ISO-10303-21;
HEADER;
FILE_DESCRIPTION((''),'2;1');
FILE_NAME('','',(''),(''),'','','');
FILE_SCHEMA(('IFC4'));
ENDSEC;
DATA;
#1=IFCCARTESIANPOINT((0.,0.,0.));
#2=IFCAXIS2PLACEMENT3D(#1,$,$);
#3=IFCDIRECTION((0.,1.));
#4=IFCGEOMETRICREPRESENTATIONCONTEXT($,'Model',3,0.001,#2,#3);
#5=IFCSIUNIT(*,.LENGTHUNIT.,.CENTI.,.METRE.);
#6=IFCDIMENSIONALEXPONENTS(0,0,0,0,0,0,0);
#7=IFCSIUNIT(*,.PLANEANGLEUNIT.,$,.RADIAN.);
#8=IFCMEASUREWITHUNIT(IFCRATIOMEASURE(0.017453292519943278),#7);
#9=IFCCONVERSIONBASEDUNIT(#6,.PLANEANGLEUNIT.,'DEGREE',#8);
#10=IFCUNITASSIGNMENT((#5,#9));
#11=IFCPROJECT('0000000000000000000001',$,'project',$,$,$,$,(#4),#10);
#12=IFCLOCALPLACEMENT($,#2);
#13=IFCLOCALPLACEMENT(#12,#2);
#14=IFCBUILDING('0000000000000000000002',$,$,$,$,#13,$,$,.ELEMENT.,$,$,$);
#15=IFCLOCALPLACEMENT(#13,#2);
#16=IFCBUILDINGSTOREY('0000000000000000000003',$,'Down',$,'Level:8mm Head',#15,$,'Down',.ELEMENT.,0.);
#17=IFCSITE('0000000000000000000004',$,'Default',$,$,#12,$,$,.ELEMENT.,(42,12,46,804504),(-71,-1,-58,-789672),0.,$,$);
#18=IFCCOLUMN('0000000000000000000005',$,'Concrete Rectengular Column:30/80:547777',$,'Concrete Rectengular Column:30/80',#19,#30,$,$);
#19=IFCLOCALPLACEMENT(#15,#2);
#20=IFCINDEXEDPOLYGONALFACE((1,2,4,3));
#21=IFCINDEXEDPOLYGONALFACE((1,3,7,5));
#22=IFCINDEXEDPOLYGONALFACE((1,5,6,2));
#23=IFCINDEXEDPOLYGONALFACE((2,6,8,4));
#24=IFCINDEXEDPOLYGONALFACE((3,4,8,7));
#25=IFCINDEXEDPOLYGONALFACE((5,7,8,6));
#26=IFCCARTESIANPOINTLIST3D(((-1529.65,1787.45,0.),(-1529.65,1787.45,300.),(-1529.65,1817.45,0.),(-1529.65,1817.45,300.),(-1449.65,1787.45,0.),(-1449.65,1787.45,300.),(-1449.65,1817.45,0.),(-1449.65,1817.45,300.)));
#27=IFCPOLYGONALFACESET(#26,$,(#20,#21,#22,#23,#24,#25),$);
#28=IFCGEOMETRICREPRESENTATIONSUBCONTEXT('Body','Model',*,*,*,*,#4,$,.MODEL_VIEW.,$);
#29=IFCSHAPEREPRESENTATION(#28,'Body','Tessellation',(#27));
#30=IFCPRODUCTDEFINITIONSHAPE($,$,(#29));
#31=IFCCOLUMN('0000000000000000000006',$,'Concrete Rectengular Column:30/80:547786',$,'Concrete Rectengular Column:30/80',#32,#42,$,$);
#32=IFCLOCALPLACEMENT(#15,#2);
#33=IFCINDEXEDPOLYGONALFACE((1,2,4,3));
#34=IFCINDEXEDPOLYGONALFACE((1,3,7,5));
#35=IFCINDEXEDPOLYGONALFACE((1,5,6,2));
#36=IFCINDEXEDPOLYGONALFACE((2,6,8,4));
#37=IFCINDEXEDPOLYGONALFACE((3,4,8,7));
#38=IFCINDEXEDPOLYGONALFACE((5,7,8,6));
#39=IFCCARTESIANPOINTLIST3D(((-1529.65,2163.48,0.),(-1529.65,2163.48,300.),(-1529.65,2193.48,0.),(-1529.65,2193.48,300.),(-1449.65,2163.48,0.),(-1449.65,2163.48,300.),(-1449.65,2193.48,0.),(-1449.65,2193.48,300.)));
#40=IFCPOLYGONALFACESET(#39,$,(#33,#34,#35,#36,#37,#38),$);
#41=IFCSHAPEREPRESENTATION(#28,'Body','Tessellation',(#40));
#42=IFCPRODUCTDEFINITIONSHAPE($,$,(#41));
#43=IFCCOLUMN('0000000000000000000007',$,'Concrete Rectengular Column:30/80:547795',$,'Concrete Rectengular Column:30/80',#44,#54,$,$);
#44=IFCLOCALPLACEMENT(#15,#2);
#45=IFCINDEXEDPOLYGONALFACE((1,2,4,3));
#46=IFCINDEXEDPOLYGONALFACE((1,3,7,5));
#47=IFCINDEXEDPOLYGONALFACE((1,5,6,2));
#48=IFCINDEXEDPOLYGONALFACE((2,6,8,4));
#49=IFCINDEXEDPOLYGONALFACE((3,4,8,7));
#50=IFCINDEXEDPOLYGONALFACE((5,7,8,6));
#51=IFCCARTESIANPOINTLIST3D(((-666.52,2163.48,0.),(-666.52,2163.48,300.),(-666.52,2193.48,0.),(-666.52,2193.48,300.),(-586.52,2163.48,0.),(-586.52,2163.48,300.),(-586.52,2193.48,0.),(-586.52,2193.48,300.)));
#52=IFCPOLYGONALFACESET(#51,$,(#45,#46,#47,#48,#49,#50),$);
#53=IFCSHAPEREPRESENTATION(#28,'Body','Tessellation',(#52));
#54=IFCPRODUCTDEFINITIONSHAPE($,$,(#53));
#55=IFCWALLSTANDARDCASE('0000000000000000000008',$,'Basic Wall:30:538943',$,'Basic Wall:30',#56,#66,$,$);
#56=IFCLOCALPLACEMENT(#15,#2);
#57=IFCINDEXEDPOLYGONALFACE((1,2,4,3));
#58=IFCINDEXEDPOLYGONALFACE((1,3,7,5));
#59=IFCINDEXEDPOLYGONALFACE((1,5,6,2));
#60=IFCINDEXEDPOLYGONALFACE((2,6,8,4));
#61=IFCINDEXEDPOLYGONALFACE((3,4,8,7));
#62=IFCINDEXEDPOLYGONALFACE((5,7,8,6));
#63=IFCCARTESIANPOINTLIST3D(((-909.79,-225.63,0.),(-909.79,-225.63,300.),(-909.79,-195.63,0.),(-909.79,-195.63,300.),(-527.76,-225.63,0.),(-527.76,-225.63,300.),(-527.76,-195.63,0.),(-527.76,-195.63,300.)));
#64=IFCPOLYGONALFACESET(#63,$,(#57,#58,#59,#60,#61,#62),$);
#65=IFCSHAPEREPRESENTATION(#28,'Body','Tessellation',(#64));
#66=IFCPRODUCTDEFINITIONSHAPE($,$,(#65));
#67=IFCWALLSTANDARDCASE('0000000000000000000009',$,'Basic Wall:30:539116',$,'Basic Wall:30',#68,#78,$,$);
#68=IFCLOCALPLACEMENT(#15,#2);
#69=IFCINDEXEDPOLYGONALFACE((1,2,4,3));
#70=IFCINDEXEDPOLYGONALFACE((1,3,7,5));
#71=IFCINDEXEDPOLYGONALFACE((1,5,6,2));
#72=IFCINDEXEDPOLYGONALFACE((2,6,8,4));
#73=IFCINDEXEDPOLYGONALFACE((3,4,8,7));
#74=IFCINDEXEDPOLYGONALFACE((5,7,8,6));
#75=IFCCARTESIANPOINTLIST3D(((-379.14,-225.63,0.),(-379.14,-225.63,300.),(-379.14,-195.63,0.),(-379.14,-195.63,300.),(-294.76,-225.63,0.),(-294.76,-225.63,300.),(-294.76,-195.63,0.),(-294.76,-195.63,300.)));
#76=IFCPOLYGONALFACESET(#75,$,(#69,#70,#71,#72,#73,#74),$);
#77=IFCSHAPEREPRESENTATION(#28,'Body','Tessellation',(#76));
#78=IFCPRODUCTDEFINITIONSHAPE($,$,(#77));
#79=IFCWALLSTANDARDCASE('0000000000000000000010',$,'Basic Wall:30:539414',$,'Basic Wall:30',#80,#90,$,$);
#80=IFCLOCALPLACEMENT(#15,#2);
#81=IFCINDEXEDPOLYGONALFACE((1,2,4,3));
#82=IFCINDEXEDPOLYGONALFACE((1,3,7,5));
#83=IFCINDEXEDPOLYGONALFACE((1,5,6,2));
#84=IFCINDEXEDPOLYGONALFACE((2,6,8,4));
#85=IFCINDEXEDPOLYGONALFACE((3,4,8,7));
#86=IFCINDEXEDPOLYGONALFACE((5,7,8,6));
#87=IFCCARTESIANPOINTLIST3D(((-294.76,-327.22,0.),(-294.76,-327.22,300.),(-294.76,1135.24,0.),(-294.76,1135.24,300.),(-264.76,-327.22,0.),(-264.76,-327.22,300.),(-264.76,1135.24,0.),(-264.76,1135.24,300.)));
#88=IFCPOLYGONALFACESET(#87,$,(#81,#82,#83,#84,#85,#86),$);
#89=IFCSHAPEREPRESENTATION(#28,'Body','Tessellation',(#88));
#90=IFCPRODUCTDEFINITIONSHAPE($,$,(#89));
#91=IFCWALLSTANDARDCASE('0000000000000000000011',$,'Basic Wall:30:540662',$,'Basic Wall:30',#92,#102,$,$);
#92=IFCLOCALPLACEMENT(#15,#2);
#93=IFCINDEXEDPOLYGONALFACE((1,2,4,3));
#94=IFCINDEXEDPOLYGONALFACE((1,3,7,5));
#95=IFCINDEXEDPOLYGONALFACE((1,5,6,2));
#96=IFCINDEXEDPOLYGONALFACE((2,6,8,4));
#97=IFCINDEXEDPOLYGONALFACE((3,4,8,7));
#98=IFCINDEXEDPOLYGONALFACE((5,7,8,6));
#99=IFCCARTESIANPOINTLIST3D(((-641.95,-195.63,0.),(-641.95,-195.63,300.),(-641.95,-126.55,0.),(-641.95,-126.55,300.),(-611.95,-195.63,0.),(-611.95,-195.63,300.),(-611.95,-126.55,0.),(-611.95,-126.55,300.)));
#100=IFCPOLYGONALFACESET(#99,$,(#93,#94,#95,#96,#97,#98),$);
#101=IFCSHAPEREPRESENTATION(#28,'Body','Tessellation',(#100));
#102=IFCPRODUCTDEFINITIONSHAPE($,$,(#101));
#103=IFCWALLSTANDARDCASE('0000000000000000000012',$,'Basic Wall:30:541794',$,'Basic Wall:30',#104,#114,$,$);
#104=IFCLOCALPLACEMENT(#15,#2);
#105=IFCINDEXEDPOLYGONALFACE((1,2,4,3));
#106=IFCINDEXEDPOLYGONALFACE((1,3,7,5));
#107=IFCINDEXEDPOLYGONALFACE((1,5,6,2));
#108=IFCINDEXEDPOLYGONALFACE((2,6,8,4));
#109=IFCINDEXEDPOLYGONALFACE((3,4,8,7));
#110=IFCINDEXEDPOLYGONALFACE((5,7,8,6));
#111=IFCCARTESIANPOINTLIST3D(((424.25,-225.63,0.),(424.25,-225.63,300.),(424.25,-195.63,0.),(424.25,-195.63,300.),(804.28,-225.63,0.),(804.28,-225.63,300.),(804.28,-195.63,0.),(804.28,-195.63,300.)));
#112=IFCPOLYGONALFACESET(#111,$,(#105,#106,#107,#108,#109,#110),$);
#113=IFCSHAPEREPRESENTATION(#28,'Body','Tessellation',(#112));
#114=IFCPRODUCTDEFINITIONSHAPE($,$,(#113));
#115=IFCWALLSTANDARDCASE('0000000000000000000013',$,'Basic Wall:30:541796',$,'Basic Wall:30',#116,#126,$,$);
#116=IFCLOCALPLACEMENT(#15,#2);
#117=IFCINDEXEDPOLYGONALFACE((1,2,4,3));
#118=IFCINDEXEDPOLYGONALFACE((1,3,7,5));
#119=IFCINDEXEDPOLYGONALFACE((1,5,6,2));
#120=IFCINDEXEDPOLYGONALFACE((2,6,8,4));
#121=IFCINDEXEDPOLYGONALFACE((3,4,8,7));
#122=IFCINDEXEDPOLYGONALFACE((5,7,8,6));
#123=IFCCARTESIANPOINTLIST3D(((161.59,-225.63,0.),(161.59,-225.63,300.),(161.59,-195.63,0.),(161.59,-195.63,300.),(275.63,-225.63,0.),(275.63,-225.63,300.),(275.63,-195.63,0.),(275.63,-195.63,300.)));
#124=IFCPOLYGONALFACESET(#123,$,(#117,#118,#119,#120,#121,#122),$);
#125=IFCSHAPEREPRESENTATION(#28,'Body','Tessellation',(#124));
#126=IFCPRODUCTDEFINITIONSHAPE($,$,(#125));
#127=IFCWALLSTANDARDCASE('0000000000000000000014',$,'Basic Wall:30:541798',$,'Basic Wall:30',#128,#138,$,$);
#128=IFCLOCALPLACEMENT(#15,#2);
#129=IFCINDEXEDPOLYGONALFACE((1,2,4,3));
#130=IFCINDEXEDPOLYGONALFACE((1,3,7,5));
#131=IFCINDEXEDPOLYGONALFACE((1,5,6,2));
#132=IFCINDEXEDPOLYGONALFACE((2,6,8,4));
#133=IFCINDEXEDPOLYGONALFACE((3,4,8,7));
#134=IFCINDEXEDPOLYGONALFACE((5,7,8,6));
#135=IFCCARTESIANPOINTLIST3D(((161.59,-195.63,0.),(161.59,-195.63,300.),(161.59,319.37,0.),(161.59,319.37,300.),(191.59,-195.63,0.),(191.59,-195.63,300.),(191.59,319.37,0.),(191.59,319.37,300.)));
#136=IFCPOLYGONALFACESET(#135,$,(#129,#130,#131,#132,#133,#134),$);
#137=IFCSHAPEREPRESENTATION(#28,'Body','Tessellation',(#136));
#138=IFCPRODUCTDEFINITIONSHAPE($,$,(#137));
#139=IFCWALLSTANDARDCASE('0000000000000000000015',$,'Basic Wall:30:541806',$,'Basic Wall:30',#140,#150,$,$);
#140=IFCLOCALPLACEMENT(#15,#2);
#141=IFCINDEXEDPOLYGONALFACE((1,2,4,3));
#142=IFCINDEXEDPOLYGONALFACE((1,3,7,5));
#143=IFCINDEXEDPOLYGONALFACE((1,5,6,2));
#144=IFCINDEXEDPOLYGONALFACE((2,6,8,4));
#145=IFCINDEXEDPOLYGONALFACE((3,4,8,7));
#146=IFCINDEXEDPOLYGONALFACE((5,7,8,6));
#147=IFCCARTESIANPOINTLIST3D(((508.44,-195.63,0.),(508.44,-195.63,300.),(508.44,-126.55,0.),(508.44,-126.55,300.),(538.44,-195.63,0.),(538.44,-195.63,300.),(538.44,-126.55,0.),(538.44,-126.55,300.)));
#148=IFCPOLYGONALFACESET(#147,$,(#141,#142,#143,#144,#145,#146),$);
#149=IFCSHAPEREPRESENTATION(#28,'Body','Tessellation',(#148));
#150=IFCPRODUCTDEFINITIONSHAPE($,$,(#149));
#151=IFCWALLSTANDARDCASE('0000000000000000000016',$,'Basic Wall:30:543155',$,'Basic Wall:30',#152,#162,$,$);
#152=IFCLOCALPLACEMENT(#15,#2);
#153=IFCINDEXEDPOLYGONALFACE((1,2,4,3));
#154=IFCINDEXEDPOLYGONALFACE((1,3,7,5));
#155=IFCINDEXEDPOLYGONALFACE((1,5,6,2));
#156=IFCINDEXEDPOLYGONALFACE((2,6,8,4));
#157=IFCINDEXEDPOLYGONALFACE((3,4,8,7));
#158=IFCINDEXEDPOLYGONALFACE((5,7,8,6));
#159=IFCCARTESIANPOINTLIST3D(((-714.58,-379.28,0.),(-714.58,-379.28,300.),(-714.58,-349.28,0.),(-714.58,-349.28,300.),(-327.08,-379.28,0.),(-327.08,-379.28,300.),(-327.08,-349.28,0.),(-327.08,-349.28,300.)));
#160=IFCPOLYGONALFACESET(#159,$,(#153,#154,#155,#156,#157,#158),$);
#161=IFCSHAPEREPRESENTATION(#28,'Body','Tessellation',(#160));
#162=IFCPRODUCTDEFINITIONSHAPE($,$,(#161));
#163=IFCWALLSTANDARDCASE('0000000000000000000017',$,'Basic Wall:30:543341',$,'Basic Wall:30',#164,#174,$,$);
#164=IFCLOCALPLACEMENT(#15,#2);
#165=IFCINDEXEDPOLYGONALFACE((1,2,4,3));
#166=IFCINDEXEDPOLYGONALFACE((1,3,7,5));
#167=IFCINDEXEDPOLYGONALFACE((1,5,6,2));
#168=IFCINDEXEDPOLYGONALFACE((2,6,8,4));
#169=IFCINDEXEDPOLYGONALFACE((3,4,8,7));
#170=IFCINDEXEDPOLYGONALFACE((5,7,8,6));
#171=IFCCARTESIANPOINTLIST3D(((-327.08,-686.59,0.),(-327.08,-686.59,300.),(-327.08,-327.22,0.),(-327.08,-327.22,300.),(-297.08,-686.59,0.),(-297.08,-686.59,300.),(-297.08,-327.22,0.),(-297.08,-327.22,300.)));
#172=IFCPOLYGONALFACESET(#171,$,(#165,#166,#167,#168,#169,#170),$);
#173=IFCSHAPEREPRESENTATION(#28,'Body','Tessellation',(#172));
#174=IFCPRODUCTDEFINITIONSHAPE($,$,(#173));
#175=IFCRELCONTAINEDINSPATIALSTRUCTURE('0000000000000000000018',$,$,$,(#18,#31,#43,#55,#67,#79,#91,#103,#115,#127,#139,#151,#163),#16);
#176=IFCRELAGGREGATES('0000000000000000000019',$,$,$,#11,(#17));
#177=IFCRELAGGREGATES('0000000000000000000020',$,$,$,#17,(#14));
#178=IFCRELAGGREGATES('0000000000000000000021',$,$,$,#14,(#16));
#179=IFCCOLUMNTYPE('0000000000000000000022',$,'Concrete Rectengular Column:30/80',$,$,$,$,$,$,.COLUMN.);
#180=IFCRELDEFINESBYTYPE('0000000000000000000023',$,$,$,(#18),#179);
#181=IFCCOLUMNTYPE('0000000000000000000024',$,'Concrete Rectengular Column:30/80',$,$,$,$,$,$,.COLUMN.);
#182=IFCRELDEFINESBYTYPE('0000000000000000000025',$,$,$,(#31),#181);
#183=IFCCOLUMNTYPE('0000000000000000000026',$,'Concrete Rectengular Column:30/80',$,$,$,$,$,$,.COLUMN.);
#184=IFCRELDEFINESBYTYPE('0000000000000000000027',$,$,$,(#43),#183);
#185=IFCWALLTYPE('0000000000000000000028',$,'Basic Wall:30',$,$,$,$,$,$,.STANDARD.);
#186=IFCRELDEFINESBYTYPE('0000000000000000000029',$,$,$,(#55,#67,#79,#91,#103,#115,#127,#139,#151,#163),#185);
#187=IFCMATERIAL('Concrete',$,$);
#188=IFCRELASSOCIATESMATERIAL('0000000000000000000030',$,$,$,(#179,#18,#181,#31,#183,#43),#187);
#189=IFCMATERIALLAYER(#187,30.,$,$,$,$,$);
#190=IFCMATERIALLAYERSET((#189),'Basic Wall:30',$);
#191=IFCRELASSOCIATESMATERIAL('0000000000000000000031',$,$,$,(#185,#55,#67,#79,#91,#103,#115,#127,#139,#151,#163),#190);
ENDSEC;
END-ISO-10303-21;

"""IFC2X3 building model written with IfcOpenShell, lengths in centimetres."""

from ifc_helpers import new_model, entity, si_unit, converted_unit, direction, frame, frame_2d, origin, origin_2d_with_axis, place, context, subcontext, project, spatial, rectangle, extrude, source, transform, mapped, material, layer, layer_set, layer_usage, type_object, type_shapes, element, save


model = new_model("IFC2X3")

# Units and contexts
model_context = context("Model", 3, precision=0.001, world=origin(), true_north=direction((0.0, 1.0)))
body_context = subcontext(model_context, "Body", "Model", "MODEL_VIEW")
ifc_project = project(units=[si_unit("LENGTHUNIT", "METRE", prefix="CENTI"), converted_unit("PLANEANGLEUNIT", "DEGREE", entity("IfcRatioMeasure", 0.017453292519943278), si_unit("PLANEANGLEUNIT", "RADIAN"), dimensions=[0, 0, 0, 0, 0, 0, 0])], contexts=[model_context])

# Site, building, storey
site_placement = place(None, origin())
site = spatial("IfcSite", under=ifc_project, at=site_placement, Name="Default", CompositionType="ELEMENT", RefLatitude=(42, 12, 46, 804504), RefLongitude=(-71, -1, -58, -789672), RefElevation=0.0)
building_placement = place(site_placement, origin())
building = spatial("IfcBuilding", under=site, at=building_placement, CompositionType="ELEMENT")
storey_placement = place(building_placement, origin())
storey = spatial("IfcBuildingStorey", under=building, at=storey_placement, Name="Down", ObjectType="Level:8mm Head", LongName="Down", CompositionType="ELEMENT", Elevation=0.0)

# Columns
ifc_material = material(Name="Concrete")
column_type_1 = type_object("IfcColumnType", Name="Concrete Rectengular Column:30/80", PredefinedType="COLUMN", material=ifc_material)
shared_shape_1 = source(origin(), body_context, "Body", "SweptSolid", [
    extrude(rectangle(XDim=30.0, YDim=80.0, at=origin_2d_with_axis()), frame((-1489.65, 1802.45, 0.0), z_axis=(0.0, 0.0, 1.0), x_axis=(0.0, -1.0, 0.0)), (0.0, 0.0, 1.0), 300.0),
])
type_shapes(column_type_1, [shared_shape_1])
column_1_placement = place(storey_placement, origin())
element("IfcColumn", 1, at=column_1_placement, inside=storey, type_object=column_type_1, material=ifc_material, Name="Concrete Rectengular Column:30/80:547777", ObjectType="Concrete Rectengular Column:30/80", context=body_context, shape_type="MappedRepresentation", body=[
    mapped(shared_shape_1, transform((0.0, 0.0, 0.0), scale=1.0)),
])
column_type_2 = type_object("IfcColumnType", Name="Concrete Rectengular Column:30/80", PredefinedType="COLUMN", material=ifc_material)
shared_shape_2 = source(origin(), body_context, "Body", "SweptSolid", [
    extrude(rectangle(XDim=30.0, YDim=80.0, at=origin_2d_with_axis()), frame((-1489.65, 2178.48, 0.0), z_axis=(0.0, 0.0, 1.0), x_axis=(0.0, -1.0, 0.0)), (0.0, 0.0, 1.0), 300.0),
])
type_shapes(column_type_2, [shared_shape_2])
column_2_placement = place(storey_placement, origin())
element("IfcColumn", 2, at=column_2_placement, inside=storey, type_object=column_type_2, material=ifc_material, Name="Concrete Rectengular Column:30/80:547786", ObjectType="Concrete Rectengular Column:30/80", context=body_context, shape_type="MappedRepresentation", body=[
    mapped(shared_shape_2, transform((0.0, 0.0, 0.0), scale=1.0)),
])
column_type_3 = type_object("IfcColumnType", Name="Concrete Rectengular Column:30/80", PredefinedType="COLUMN", material=ifc_material)
shared_shape_3 = source(origin(), body_context, "Body", "SweptSolid", [
    extrude(rectangle(XDim=30.0, YDim=80.0, at=origin_2d_with_axis()), frame((-626.52, 2178.48, 0.0), z_axis=(0.0, 0.0, 1.0), x_axis=(0.0, -1.0, 0.0)), (0.0, 0.0, 1.0), 300.0),
])
type_shapes(column_type_3, [shared_shape_3])
column_3_placement = place(storey_placement, origin())
element("IfcColumn", 3, at=column_3_placement, inside=storey, type_object=column_type_3, material=ifc_material, Name="Concrete Rectengular Column:30/80:547795", ObjectType="Concrete Rectengular Column:30/80", context=body_context, shape_type="MappedRepresentation", body=[
    mapped(shared_shape_3, transform((0.0, 0.0, 0.0), scale=1.0)),
])

# Walls
ifc_layer = layer(ifc_material, 30.0)
ifc_layer_set = layer_set([ifc_layer], Name="Basic Wall:30")
ifc_layer_usage_1 = layer_usage(ifc_layer_set, "AXIS2", "POSITIVE", -15.0)
wall_type = type_object("IfcWallType", Name="Basic Wall:30", PredefinedType="STANDARD", material=ifc_layer_set)
wall_1_placement = place(storey_placement, frame((-909.79, -210.63, 0.0)))
element("IfcWallStandardCase", 4, at=wall_1_placement, inside=storey, type_object=wall_type, material=ifc_layer_usage_1, Name="Basic Wall:30:538943", ObjectType="Basic Wall:30", context=body_context, shape_type="SweptSolid", body=[
    extrude(rectangle(XDim=382.04, YDim=30.0, at=frame_2d((191.02, 0.0), x_axis=(-1.0, 0.0))), origin(), (0.0, 0.0, 1.0), 300.0),
])
ifc_layer_usage_2 = layer_usage(ifc_layer_set, "AXIS2", "POSITIVE", -15.0)
wall_2_placement = place(storey_placement, frame((-379.14, -210.63, 0.0)))
element("IfcWallStandardCase", 5, at=wall_2_placement, inside=storey, type_object=wall_type, material=ifc_layer_usage_2, Name="Basic Wall:30:539116", ObjectType="Basic Wall:30", context=body_context, shape_type="SweptSolid", body=[
    extrude(rectangle(XDim=84.38, YDim=30.0, at=frame_2d((42.19, 0.0), x_axis=(-1.0, 0.0))), origin(), (0.0, 0.0, 1.0), 300.0),
])
ifc_layer_usage_3 = layer_usage(ifc_layer_set, "AXIS2", "NEGATIVE", 15.0)
wall_3_placement = place(storey_placement, frame((-279.76, -327.22, 0.0), z_axis=(0.0, 0.0, 1.0), x_axis=(0.0, 1.0, 0.0)))
element("IfcWallStandardCase", 6, at=wall_3_placement, inside=storey, type_object=wall_type, material=ifc_layer_usage_3, Name="Basic Wall:30:539414", ObjectType="Basic Wall:30", context=body_context, shape_type="SweptSolid", body=[
    extrude(rectangle(XDim=1462.46, YDim=30.0, at=frame_2d((731.23, 0.0), x_axis=(-1.0, 0.0))), origin(), (0.0, 0.0, 1.0), 300.0),
])
ifc_layer_usage_4 = layer_usage(ifc_layer_set, "AXIS2", "NEGATIVE", 15.0)
wall_4_placement = place(storey_placement, frame((-626.95, -195.63, 0.0), z_axis=(0.0, 0.0, 1.0), x_axis=(0.0, 1.0, 0.0)))
element("IfcWallStandardCase", 7, at=wall_4_placement, inside=storey, type_object=wall_type, material=ifc_layer_usage_4, Name="Basic Wall:30:540662", ObjectType="Basic Wall:30", context=body_context, shape_type="SweptSolid", body=[
    extrude(rectangle(XDim=69.08, YDim=30.0, at=frame_2d((34.54, 0.0), x_axis=(-1.0, 0.0))), origin(), (0.0, 0.0, 1.0), 300.0),
])
ifc_layer_usage_5 = layer_usage(ifc_layer_set, "AXIS2", "NEGATIVE", 15.0)
wall_5_placement = place(storey_placement, frame((804.28, -210.63, 0.0), z_axis=(0.0, 0.0, 1.0), x_axis=(-1.0, 0.0, 0.0)))
element("IfcWallStandardCase", 8, at=wall_5_placement, inside=storey, type_object=wall_type, material=ifc_layer_usage_5, Name="Basic Wall:30:541794", ObjectType="Basic Wall:30", context=body_context, shape_type="SweptSolid", body=[
    extrude(rectangle(XDim=380.04, YDim=30.0, at=frame_2d((190.02, 0.0), x_axis=(-1.0, 0.0))), origin(), (0.0, 0.0, 1.0), 300.0),
])
ifc_layer_usage_6 = layer_usage(ifc_layer_set, "AXIS2", "NEGATIVE", 15.0)
wall_6_placement = place(storey_placement, frame((275.63, -210.63, 0.0), z_axis=(0.0, 0.0, 1.0), x_axis=(-1.0, 0.0, 0.0)))
element("IfcWallStandardCase", 9, at=wall_6_placement, inside=storey, type_object=wall_type, material=ifc_layer_usage_6, Name="Basic Wall:30:541796", ObjectType="Basic Wall:30", context=body_context, shape_type="SweptSolid", body=[
    extrude(rectangle(XDim=114.04, YDim=30.0, at=frame_2d((57.02, 0.0), x_axis=(-1.0, 0.0))), origin(), (0.0, 0.0, 1.0), 300.0),
])
ifc_layer_usage_7 = layer_usage(ifc_layer_set, "AXIS2", "POSITIVE", -15.0)
wall_7_placement = place(storey_placement, frame((176.59, -195.63, 0.0), z_axis=(0.0, 0.0, 1.0), x_axis=(0.0, 1.0, 0.0)))
element("IfcWallStandardCase", 10, at=wall_7_placement, inside=storey, type_object=wall_type, material=ifc_layer_usage_7, Name="Basic Wall:30:541798", ObjectType="Basic Wall:30", context=body_context, shape_type="SweptSolid", body=[
    extrude(rectangle(XDim=515.0, YDim=30.0, at=frame_2d((257.5, 0.0), x_axis=(-1.0, 0.0))), origin(), (0.0, 0.0, 1.0), 300.0),
])
ifc_layer_usage_8 = layer_usage(ifc_layer_set, "AXIS2", "POSITIVE", -15.0)
wall_8_placement = place(storey_placement, frame((523.44, -195.63, 0.0), z_axis=(0.0, 0.0, 1.0), x_axis=(0.0, 1.0, 0.0)))
element("IfcWallStandardCase", 11, at=wall_8_placement, inside=storey, type_object=wall_type, material=ifc_layer_usage_8, Name="Basic Wall:30:541806", ObjectType="Basic Wall:30", context=body_context, shape_type="SweptSolid", body=[
    extrude(rectangle(XDim=69.08, YDim=30.0, at=frame_2d((34.54, 0.0), x_axis=(-1.0, 0.0))), origin(), (0.0, 0.0, 1.0), 300.0),
])
ifc_layer_usage_9 = layer_usage(ifc_layer_set, "AXIS2", "POSITIVE", -15.0)
wall_9_placement = place(storey_placement, frame((-714.58, -364.28, 0.0)))
element("IfcWallStandardCase", 12, at=wall_9_placement, inside=storey, type_object=wall_type, material=ifc_layer_usage_9, Name="Basic Wall:30:543155", ObjectType="Basic Wall:30", context=body_context, shape_type="SweptSolid", body=[
    extrude(rectangle(XDim=387.49, YDim=30.0, at=frame_2d((193.75, 0.0), x_axis=(-1.0, 0.0))), origin(), (0.0, 0.0, 1.0), 300.0),
])
ifc_layer_usage_10 = layer_usage(ifc_layer_set, "AXIS2", "POSITIVE", -15.0)
wall_10_placement = place(storey_placement, frame((-312.08, -327.22, 0.0), z_axis=(0.0, 0.0, 1.0), x_axis=(0.0, -1.0, 0.0)))
element("IfcWallStandardCase", 13, at=wall_10_placement, inside=storey, type_object=wall_type, material=ifc_layer_usage_10, Name="Basic Wall:30:543341", ObjectType="Basic Wall:30", context=body_context, shape_type="SweptSolid", body=[
    extrude(rectangle(XDim=359.37, YDim=30.0, at=frame_2d((179.68, 0.0), x_axis=(-1.0, 0.0))), origin(), (0.0, 0.0, 1.0), 300.0),
])

save(model, "model.ifc")
